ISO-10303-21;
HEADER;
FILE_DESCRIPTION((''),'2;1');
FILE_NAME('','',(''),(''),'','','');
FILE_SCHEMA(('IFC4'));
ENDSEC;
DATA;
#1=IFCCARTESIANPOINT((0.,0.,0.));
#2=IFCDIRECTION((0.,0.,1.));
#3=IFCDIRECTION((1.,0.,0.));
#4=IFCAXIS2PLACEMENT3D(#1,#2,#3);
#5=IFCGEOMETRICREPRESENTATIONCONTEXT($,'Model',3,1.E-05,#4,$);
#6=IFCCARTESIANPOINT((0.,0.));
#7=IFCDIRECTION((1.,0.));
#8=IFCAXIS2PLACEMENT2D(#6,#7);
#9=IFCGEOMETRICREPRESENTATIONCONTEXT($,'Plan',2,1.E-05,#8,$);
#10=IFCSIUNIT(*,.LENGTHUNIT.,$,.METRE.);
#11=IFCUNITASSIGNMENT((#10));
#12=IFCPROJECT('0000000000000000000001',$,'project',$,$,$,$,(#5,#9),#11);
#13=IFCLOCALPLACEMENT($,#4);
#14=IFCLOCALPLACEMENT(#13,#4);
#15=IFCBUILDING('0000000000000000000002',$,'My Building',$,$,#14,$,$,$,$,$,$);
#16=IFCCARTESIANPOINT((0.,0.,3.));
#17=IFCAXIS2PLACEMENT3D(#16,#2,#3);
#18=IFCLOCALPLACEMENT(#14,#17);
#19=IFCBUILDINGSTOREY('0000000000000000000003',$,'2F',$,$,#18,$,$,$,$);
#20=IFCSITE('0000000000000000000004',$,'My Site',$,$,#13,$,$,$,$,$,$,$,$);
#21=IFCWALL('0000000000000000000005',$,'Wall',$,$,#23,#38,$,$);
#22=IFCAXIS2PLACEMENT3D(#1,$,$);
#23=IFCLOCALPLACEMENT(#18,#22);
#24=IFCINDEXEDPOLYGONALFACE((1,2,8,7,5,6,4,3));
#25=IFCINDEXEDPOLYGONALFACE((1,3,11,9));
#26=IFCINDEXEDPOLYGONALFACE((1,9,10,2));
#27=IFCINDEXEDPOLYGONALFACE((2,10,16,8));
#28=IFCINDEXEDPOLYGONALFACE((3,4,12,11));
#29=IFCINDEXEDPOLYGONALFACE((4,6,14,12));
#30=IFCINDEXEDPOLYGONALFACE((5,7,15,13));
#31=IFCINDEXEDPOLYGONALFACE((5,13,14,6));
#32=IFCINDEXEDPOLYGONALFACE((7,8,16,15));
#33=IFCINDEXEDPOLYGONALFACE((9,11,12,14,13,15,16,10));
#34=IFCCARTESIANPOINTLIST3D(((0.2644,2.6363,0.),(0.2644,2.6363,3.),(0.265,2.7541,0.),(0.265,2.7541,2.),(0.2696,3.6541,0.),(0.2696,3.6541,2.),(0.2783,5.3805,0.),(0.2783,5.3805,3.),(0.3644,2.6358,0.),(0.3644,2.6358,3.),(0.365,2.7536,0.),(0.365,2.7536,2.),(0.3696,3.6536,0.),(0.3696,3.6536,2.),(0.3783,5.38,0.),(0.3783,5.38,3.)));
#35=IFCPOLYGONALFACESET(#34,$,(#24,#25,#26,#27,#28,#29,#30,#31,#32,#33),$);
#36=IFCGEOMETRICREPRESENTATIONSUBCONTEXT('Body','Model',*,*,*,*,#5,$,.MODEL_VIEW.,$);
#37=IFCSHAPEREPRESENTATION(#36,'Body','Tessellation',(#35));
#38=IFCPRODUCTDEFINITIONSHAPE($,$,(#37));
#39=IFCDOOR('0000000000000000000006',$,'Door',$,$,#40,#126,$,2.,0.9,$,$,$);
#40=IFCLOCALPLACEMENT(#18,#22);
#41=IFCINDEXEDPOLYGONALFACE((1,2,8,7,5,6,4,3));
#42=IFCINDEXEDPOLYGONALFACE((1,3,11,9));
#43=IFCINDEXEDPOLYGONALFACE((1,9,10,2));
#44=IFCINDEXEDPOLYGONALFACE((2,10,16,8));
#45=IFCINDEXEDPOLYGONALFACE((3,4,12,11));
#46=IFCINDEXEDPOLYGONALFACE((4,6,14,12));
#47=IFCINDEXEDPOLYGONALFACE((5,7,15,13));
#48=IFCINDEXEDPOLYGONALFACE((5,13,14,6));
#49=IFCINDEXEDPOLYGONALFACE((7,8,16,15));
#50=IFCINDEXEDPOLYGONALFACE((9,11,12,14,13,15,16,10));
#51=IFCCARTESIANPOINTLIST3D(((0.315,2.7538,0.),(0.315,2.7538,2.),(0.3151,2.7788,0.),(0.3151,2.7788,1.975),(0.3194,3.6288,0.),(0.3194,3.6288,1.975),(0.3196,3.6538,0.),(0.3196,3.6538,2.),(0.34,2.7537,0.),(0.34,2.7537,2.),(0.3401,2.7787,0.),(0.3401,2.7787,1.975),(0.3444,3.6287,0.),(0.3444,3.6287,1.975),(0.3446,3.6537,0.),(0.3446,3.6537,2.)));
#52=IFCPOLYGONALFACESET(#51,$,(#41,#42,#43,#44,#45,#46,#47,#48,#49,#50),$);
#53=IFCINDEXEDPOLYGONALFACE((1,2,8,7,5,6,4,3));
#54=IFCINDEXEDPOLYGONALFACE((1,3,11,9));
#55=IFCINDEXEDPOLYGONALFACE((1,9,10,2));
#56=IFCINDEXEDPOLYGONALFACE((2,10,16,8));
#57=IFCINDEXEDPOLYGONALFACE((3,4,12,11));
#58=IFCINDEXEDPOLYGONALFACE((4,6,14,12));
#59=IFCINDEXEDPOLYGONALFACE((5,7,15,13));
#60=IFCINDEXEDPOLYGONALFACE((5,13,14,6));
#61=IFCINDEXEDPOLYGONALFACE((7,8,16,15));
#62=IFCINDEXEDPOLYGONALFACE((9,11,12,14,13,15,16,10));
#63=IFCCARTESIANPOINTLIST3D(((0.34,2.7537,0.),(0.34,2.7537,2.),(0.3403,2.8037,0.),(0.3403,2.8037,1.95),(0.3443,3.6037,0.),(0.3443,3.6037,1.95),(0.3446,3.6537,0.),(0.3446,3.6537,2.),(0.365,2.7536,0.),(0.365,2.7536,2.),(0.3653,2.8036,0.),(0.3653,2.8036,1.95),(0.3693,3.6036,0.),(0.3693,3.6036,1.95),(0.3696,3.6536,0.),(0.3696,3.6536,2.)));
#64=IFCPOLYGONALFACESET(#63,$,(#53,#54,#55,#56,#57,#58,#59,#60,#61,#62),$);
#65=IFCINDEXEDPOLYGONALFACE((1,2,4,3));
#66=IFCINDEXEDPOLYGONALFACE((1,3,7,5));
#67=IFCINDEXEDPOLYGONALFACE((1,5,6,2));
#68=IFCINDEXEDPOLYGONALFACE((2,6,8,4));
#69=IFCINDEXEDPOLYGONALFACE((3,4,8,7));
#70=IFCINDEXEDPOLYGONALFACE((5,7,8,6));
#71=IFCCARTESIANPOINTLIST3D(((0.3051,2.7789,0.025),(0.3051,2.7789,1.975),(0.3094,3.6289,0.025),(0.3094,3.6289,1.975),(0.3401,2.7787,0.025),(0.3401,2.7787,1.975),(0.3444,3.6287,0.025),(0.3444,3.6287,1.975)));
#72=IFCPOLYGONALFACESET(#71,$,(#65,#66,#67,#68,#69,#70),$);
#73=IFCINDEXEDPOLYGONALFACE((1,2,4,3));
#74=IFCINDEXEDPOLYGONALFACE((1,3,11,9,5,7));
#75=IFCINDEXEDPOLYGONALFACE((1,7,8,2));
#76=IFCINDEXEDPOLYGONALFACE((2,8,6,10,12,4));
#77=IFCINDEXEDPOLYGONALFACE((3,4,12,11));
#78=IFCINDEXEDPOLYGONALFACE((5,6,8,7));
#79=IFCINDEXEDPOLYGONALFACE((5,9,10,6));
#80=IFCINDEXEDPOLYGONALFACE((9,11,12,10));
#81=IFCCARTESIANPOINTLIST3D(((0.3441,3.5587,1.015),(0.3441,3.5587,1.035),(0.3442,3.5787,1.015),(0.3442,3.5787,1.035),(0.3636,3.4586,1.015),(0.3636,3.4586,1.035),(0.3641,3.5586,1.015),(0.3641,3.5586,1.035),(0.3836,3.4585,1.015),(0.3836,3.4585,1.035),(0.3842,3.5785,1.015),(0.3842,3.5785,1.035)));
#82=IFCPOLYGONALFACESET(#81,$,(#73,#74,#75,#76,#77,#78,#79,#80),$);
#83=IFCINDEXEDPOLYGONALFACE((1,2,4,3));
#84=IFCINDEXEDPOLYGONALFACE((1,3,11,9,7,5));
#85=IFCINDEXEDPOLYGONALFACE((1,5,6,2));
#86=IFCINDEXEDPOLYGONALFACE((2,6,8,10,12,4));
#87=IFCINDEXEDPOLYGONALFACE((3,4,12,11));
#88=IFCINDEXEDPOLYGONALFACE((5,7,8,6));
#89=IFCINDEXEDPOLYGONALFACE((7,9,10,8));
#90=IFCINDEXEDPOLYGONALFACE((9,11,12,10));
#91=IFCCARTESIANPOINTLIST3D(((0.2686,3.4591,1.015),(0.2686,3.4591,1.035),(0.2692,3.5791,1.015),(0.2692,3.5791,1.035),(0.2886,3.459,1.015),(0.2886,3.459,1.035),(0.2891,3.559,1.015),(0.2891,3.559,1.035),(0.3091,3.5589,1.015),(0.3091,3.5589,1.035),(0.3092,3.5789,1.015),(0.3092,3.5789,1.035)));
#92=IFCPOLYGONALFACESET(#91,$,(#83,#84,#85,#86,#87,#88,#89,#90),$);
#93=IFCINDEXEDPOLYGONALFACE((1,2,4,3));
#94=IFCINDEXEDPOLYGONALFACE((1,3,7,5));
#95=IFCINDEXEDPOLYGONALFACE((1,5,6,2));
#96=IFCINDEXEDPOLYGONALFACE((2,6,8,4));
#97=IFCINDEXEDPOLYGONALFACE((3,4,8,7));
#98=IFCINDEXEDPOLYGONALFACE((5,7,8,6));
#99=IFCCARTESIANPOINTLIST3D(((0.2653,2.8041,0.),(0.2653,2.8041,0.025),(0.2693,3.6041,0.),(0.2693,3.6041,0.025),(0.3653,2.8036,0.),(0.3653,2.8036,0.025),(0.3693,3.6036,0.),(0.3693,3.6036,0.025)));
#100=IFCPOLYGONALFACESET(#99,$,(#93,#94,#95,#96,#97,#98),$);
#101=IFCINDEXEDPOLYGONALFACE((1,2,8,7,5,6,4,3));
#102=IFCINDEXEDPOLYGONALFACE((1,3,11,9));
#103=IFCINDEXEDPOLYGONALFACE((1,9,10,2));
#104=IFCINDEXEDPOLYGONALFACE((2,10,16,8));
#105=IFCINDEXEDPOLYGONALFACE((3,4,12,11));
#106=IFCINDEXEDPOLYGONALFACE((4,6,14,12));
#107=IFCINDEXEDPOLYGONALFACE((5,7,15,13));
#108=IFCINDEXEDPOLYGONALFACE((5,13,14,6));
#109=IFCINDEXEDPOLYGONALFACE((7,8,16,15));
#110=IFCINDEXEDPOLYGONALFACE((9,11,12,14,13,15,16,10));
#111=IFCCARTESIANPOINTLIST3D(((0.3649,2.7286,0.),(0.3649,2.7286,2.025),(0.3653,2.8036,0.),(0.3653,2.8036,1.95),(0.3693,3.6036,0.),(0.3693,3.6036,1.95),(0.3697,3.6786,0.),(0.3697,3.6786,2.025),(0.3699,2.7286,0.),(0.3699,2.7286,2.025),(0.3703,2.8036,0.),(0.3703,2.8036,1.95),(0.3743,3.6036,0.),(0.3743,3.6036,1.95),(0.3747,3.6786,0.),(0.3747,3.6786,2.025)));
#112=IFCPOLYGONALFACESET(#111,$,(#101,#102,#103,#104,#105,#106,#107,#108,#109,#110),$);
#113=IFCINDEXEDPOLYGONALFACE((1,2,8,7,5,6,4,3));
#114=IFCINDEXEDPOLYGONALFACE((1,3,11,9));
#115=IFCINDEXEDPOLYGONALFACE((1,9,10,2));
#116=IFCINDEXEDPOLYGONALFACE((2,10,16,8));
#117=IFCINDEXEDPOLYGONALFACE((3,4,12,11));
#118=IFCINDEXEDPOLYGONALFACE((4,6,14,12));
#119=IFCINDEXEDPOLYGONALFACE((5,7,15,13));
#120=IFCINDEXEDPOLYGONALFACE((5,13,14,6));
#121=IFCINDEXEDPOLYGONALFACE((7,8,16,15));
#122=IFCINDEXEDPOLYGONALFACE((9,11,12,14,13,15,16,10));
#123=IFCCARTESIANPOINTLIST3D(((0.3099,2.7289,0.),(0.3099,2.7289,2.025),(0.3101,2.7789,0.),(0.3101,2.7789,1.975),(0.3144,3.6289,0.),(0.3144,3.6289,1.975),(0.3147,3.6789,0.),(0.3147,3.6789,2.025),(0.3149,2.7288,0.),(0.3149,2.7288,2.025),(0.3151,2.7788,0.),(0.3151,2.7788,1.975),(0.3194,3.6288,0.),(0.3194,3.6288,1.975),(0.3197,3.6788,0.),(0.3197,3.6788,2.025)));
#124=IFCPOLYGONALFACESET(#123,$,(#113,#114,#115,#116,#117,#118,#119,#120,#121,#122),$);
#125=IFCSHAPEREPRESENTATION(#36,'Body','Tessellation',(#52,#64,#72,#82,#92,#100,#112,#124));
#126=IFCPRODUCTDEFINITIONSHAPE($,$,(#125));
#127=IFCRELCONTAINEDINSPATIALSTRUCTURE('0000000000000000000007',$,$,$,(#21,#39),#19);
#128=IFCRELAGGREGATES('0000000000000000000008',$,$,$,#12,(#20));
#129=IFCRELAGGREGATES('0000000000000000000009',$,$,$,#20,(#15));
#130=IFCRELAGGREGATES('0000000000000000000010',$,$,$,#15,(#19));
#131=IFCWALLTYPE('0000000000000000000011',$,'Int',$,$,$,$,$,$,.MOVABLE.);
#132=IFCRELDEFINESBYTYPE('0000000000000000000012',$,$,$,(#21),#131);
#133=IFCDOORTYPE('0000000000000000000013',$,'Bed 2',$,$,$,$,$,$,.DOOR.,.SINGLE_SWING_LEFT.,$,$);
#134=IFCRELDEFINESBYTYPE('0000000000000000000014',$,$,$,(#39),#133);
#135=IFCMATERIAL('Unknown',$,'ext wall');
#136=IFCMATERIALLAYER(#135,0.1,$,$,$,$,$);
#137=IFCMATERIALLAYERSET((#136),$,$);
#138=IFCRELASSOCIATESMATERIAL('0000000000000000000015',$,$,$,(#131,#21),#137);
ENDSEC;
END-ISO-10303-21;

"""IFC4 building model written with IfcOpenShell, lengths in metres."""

from ifc_helpers import new_model, entity, si_unit, frame, origin_with_axes, origin_2d_with_axis, place, context, subcontext, project, spatial, line, indexed_curve, outline, extrude, shape, source, transform, mapped, material, layer, layer_set, layer_usage, type_object, type_shapes, element, fill, save


model = new_model("IFC4")

# Units and contexts
model_context = context("Model", 3, precision=1e-05, world=origin_with_axes())
plan_context = context("Plan", 2, precision=1e-05, world=origin_2d_with_axis())
body_context_1 = subcontext(model_context, "Body", "Model", "MODEL_VIEW")
body_context_2 = subcontext(plan_context, "Body", "Plan", "PLAN_VIEW")
ifc_project = project(units=[si_unit("LENGTHUNIT", "METRE")], contexts=[model_context, plan_context])

# Site, building, storey
site_placement = place(None, origin_with_axes())
site = spatial("IfcSite", under=ifc_project, at=site_placement, Name="My Site")
building_placement = place(site_placement, origin_with_axes())
building = spatial("IfcBuilding", under=site, at=building_placement, Name="My Building")
storey_placement = place(building_placement, frame((0.0, 0.0, 3.0), z_axis=(0.0, 0.0, 1.0), x_axis=(1.0, 0.0, 0.0)))
storey = spatial("IfcBuildingStorey", under=building, at=storey_placement, Name="2F")

# Shared definitions
ifc_material = material(Name="Unknown", Category="ext wall")

# Shared definitions
ifc_layer_1 = layer(ifc_material, 0.1)
ifc_layer_set_1 = layer_set([ifc_layer_1])
wall_type_1 = type_object("IfcWallType", Name="Int", PredefinedType="MOVABLE", material=ifc_layer_set_1)

# Wall, opening, door
ifc_layer_usage_1 = layer_usage(ifc_layer_set_1, "AXIS2", "POSITIVE", 0.0)
wall_1_placement = place(storey_placement, frame((0.3644, 2.6358, 0.0), z_axis=(0.0, 0.0, 1.0), x_axis=(0.005081, 0.999987, 0.0)))
wall_1 = element("IfcWall", 1, at=wall_1_placement, inside=storey, type_object=wall_type_1, material=ifc_layer_usage_1, Name="Wall", context=body_context_1, shape_type="SweptSolid", body=[
    extrude(outline(indexed_curve([(0.0, 0.0), (0.0, 0.1), (2.7442, 0.1), (2.7442, 0.0)], segments=[line(1, 2, 3, 4, 1)])), origin_with_axes(), (0.0, 0.0, 1.0), 3.0),
])
shared_shape_1 = source(origin_with_axes(), body_context_1, "Body", "SweptSolid", [
    extrude(outline(indexed_curve([(0.0, 0.0), (0.9, 0.0), (0.9, 2.0), (0.0, 2.0)], segments=[line(1, 2, 3, 4, 1)])), frame((0.0, -0.6, 0.0), z_axis=(0.0, -1.0, 0.0), x_axis=(1.0, 0.0, 0.0)), (0.0, 0.0, -1.0), 1.2),
])
opening_1_placement = place(wall_1_placement, frame((0.1178, 0.0, 0.0), z_axis=(0.0, 0.0, 1.0), x_axis=(1.0, 0.000001, 0.0)))
opening_1 = element("IfcOpeningElement", 2, at=opening_1_placement, cuts=wall_1, PredefinedType="OPENING", context=body_context_1, shape_type="MappedRepresentation", body=[
    mapped(shared_shape_1, transform((0.0, 0.0, 0.0), x_axis=(1.0, 0.0, 0.0), y_axis=(0.0, 1.0, 0.0), z_axis=(0.0, 0.0, 1.0), scale=1.0)),
])
door_type_1 = type_object("IfcDoorType", Name="Bed 2", OperationType="SINGLE_SWING_LEFT", PredefinedType="DOOR")
shared_shape_2 = source(origin_with_axes(), body_context_1, "Body", "SweptSolid", [
    extrude(outline(indexed_curve([(0.0, 0.0), (0.0, 2.0), (0.9, 2.0), (0.9, 0.0), (0.875, 0.0), (0.875, 1.975), (0.025, 1.975), (0.025, 0.0)], segments=[line(1, 2, 3, 4, 5, 6, 7, 8, 1)])), frame((0.0, 0.025, 0.0), z_axis=(0.0, -1.0, 0.0), x_axis=(1.0, 0.0, 0.0)), (0.0, 0.0, -1.0), 0.025),
    extrude(outline(indexed_curve([(0.0, 0.0), (0.0, 2.0), (0.9, 2.0), (0.9, 0.0), (0.85, 0.0), (0.85, 1.95), (0.05, 1.95), (0.05, 0.0)], segments=[line(1, 2, 3, 4, 5, 6, 7, 8, 1)])), frame((0.0, 0.0, 0.0), z_axis=(0.0, -1.0, 0.0), x_axis=(1.0, 0.0, 0.0)), (0.0, 0.0, -1.0), 0.025),
    extrude(outline(indexed_curve([(0.0, 0.0), (0.85, 0.0), (0.85, 0.035), (0.0, 0.035)], segments=[line(1, 2, 3, 4, 1)])), frame((0.025, 0.025, 0.025), z_axis=(0.0, 0.0, 1.0), x_axis=(1.0, 0.0, 0.0)), (0.0, 0.0, 1.0), 1.95),
    extrude(outline(indexed_curve([(0.0, 0.0), (0.0, -0.04), (-0.12, -0.04), (-0.12, -0.02), (-0.02, -0.02), (-0.02, 0.0)], segments=[line(1, 2, 3, 4, 5, 6, 1)])), frame((0.825, 0.025, 1.015), z_axis=(0.0, 0.0, 1.0), x_axis=(1.0, 0.0, 0.0)), (0.0, 0.0, 1.0), 0.02),
    extrude(outline(indexed_curve([(0.0, 0.0), (0.0, 0.04), (-0.12, 0.04), (-0.12, 0.02), (-0.02, 0.02), (-0.02, 0.0)], segments=[line(1, 2, 3, 4, 5, 6, 1)])), frame((0.825, 0.06, 1.015), z_axis=(0.0, 0.0, 1.0), x_axis=(1.0, 0.0, 0.0)), (0.0, 0.0, 1.0), 0.02),
    extrude(outline(indexed_curve([(0.0, 0.0), (0.8, 0.0), (0.8, 0.1), (0.0, 0.1)], segments=[line(1, 2, 3, 4, 1)])), frame((0.05, 0.0, 0.0), z_axis=(0.0, 0.0, 1.0), x_axis=(1.0, 0.0, 0.0)), (0.0, 0.0, 1.0), 0.025),
    extrude(outline(indexed_curve([(0.0, 0.0), (0.0, 2.025), (0.95, 2.025), (0.95, 0.0), (0.875, 0.0), (0.875, 1.95), (0.075, 1.95), (0.075, 0.0)], segments=[line(1, 2, 3, 4, 5, 6, 7, 8, 1)])), frame((-0.025, -0.005, 0.0), z_axis=(0.0, -1.0, 0.0), x_axis=(1.0, 0.0, 0.0)), (0.0, 0.0, -1.0), 0.005),
    extrude(outline(indexed_curve([(0.0, 0.0), (0.0, 2.025), (0.95, 2.025), (0.95, 0.0), (0.9, 0.0), (0.9, 1.975), (0.05, 1.975), (0.05, 0.0)], segments=[line(1, 2, 3, 4, 5, 6, 7, 8, 1)])), frame((-0.025, 0.05, 0.0), z_axis=(0.0, -1.0, 0.0), x_axis=(1.0, 0.0, 0.0)), (0.0, 0.0, -1.0), 0.005),
])
shared_shape_3 = source(origin_with_axes(), body_context_2, "Body", "Curve2D", [
    entity("IfcIndexedPolyCurve", entity("IfcCartesianPointList2D", [[0.0, 0.0], [0.0, 0.05], [0.025, 0.05], [0.025, 0.025], [0.05, 0.025], [0.05, 0.0]]), [entity("IfcLineIndex", [1, 2, 3, 4, 5, 6, 1])]),
    entity("IfcIndexedPolyCurve", entity("IfcCartesianPointList2D", [[0.9, 0.0], [0.9, 0.05], [0.875, 0.05], [0.875, 0.025], [0.85, 0.025], [0.85, 0.0]]), [entity("IfcLineIndex", [1, 2, 3, 4, 5, 6, 1])]),
    entity("IfcTrimmedCurve", entity("IfcEllipse", entity("IfcAxis2Placement2D", entity("IfcCartesianPoint", [0.06, 0.05]), entity("IfcDirection", [1.0, 0.0])), 0.815, 0.85), [entity("IfcCartesianPoint", [0.875, 0.05])], [entity("IfcCartesianPoint", [0.06, 0.9])], True, "CARTESIAN"),
    entity("IfcIndexedPolyCurve", entity("IfcCartesianPointList2D", [[0.025, 0.05], [0.06, 0.05], [0.06, 0.9], [0.025, 0.9]]), [entity("IfcLineIndex", [1, 2, 3, 4, 1])]),
])
type_shapes(door_type_1, [shared_shape_2, shared_shape_3])
door_1_placement = place(opening_1_placement, frame((0.0, 0.0, 0.0), z_axis=(0.0, 0.0, 1.0), x_axis=(1.0, 0.0, 0.0)))
door_1 = element("IfcDoor", 3, at=door_1_placement, inside=storey, type_object=door_type_1, Name="Door", OverallHeight=2.0, OverallWidth=0.9, shapes=[
    shape(body_context_1, "Body", "MappedRepresentation", [mapped(shared_shape_2, transform((0.0, 0.0, 0.0), x_axis=(1.0, 0.0, 0.0), y_axis=(0.0, 1.0, 0.0), z_axis=(0.0, 0.0, 1.0), scale=1.0))]),
    shape(body_context_2, "Body", "MappedRepresentation", [mapped(shared_shape_3, transform((0.0, 0.0, 0.0), x_axis=(1.0, 0.0, 0.0), y_axis=(0.0, 1.0, 0.0), z_axis=(0.0, 0.0, 1.0), scale=1.0))]),
])
fill(opening_1, door_1)

save(model, "model.ifc")
